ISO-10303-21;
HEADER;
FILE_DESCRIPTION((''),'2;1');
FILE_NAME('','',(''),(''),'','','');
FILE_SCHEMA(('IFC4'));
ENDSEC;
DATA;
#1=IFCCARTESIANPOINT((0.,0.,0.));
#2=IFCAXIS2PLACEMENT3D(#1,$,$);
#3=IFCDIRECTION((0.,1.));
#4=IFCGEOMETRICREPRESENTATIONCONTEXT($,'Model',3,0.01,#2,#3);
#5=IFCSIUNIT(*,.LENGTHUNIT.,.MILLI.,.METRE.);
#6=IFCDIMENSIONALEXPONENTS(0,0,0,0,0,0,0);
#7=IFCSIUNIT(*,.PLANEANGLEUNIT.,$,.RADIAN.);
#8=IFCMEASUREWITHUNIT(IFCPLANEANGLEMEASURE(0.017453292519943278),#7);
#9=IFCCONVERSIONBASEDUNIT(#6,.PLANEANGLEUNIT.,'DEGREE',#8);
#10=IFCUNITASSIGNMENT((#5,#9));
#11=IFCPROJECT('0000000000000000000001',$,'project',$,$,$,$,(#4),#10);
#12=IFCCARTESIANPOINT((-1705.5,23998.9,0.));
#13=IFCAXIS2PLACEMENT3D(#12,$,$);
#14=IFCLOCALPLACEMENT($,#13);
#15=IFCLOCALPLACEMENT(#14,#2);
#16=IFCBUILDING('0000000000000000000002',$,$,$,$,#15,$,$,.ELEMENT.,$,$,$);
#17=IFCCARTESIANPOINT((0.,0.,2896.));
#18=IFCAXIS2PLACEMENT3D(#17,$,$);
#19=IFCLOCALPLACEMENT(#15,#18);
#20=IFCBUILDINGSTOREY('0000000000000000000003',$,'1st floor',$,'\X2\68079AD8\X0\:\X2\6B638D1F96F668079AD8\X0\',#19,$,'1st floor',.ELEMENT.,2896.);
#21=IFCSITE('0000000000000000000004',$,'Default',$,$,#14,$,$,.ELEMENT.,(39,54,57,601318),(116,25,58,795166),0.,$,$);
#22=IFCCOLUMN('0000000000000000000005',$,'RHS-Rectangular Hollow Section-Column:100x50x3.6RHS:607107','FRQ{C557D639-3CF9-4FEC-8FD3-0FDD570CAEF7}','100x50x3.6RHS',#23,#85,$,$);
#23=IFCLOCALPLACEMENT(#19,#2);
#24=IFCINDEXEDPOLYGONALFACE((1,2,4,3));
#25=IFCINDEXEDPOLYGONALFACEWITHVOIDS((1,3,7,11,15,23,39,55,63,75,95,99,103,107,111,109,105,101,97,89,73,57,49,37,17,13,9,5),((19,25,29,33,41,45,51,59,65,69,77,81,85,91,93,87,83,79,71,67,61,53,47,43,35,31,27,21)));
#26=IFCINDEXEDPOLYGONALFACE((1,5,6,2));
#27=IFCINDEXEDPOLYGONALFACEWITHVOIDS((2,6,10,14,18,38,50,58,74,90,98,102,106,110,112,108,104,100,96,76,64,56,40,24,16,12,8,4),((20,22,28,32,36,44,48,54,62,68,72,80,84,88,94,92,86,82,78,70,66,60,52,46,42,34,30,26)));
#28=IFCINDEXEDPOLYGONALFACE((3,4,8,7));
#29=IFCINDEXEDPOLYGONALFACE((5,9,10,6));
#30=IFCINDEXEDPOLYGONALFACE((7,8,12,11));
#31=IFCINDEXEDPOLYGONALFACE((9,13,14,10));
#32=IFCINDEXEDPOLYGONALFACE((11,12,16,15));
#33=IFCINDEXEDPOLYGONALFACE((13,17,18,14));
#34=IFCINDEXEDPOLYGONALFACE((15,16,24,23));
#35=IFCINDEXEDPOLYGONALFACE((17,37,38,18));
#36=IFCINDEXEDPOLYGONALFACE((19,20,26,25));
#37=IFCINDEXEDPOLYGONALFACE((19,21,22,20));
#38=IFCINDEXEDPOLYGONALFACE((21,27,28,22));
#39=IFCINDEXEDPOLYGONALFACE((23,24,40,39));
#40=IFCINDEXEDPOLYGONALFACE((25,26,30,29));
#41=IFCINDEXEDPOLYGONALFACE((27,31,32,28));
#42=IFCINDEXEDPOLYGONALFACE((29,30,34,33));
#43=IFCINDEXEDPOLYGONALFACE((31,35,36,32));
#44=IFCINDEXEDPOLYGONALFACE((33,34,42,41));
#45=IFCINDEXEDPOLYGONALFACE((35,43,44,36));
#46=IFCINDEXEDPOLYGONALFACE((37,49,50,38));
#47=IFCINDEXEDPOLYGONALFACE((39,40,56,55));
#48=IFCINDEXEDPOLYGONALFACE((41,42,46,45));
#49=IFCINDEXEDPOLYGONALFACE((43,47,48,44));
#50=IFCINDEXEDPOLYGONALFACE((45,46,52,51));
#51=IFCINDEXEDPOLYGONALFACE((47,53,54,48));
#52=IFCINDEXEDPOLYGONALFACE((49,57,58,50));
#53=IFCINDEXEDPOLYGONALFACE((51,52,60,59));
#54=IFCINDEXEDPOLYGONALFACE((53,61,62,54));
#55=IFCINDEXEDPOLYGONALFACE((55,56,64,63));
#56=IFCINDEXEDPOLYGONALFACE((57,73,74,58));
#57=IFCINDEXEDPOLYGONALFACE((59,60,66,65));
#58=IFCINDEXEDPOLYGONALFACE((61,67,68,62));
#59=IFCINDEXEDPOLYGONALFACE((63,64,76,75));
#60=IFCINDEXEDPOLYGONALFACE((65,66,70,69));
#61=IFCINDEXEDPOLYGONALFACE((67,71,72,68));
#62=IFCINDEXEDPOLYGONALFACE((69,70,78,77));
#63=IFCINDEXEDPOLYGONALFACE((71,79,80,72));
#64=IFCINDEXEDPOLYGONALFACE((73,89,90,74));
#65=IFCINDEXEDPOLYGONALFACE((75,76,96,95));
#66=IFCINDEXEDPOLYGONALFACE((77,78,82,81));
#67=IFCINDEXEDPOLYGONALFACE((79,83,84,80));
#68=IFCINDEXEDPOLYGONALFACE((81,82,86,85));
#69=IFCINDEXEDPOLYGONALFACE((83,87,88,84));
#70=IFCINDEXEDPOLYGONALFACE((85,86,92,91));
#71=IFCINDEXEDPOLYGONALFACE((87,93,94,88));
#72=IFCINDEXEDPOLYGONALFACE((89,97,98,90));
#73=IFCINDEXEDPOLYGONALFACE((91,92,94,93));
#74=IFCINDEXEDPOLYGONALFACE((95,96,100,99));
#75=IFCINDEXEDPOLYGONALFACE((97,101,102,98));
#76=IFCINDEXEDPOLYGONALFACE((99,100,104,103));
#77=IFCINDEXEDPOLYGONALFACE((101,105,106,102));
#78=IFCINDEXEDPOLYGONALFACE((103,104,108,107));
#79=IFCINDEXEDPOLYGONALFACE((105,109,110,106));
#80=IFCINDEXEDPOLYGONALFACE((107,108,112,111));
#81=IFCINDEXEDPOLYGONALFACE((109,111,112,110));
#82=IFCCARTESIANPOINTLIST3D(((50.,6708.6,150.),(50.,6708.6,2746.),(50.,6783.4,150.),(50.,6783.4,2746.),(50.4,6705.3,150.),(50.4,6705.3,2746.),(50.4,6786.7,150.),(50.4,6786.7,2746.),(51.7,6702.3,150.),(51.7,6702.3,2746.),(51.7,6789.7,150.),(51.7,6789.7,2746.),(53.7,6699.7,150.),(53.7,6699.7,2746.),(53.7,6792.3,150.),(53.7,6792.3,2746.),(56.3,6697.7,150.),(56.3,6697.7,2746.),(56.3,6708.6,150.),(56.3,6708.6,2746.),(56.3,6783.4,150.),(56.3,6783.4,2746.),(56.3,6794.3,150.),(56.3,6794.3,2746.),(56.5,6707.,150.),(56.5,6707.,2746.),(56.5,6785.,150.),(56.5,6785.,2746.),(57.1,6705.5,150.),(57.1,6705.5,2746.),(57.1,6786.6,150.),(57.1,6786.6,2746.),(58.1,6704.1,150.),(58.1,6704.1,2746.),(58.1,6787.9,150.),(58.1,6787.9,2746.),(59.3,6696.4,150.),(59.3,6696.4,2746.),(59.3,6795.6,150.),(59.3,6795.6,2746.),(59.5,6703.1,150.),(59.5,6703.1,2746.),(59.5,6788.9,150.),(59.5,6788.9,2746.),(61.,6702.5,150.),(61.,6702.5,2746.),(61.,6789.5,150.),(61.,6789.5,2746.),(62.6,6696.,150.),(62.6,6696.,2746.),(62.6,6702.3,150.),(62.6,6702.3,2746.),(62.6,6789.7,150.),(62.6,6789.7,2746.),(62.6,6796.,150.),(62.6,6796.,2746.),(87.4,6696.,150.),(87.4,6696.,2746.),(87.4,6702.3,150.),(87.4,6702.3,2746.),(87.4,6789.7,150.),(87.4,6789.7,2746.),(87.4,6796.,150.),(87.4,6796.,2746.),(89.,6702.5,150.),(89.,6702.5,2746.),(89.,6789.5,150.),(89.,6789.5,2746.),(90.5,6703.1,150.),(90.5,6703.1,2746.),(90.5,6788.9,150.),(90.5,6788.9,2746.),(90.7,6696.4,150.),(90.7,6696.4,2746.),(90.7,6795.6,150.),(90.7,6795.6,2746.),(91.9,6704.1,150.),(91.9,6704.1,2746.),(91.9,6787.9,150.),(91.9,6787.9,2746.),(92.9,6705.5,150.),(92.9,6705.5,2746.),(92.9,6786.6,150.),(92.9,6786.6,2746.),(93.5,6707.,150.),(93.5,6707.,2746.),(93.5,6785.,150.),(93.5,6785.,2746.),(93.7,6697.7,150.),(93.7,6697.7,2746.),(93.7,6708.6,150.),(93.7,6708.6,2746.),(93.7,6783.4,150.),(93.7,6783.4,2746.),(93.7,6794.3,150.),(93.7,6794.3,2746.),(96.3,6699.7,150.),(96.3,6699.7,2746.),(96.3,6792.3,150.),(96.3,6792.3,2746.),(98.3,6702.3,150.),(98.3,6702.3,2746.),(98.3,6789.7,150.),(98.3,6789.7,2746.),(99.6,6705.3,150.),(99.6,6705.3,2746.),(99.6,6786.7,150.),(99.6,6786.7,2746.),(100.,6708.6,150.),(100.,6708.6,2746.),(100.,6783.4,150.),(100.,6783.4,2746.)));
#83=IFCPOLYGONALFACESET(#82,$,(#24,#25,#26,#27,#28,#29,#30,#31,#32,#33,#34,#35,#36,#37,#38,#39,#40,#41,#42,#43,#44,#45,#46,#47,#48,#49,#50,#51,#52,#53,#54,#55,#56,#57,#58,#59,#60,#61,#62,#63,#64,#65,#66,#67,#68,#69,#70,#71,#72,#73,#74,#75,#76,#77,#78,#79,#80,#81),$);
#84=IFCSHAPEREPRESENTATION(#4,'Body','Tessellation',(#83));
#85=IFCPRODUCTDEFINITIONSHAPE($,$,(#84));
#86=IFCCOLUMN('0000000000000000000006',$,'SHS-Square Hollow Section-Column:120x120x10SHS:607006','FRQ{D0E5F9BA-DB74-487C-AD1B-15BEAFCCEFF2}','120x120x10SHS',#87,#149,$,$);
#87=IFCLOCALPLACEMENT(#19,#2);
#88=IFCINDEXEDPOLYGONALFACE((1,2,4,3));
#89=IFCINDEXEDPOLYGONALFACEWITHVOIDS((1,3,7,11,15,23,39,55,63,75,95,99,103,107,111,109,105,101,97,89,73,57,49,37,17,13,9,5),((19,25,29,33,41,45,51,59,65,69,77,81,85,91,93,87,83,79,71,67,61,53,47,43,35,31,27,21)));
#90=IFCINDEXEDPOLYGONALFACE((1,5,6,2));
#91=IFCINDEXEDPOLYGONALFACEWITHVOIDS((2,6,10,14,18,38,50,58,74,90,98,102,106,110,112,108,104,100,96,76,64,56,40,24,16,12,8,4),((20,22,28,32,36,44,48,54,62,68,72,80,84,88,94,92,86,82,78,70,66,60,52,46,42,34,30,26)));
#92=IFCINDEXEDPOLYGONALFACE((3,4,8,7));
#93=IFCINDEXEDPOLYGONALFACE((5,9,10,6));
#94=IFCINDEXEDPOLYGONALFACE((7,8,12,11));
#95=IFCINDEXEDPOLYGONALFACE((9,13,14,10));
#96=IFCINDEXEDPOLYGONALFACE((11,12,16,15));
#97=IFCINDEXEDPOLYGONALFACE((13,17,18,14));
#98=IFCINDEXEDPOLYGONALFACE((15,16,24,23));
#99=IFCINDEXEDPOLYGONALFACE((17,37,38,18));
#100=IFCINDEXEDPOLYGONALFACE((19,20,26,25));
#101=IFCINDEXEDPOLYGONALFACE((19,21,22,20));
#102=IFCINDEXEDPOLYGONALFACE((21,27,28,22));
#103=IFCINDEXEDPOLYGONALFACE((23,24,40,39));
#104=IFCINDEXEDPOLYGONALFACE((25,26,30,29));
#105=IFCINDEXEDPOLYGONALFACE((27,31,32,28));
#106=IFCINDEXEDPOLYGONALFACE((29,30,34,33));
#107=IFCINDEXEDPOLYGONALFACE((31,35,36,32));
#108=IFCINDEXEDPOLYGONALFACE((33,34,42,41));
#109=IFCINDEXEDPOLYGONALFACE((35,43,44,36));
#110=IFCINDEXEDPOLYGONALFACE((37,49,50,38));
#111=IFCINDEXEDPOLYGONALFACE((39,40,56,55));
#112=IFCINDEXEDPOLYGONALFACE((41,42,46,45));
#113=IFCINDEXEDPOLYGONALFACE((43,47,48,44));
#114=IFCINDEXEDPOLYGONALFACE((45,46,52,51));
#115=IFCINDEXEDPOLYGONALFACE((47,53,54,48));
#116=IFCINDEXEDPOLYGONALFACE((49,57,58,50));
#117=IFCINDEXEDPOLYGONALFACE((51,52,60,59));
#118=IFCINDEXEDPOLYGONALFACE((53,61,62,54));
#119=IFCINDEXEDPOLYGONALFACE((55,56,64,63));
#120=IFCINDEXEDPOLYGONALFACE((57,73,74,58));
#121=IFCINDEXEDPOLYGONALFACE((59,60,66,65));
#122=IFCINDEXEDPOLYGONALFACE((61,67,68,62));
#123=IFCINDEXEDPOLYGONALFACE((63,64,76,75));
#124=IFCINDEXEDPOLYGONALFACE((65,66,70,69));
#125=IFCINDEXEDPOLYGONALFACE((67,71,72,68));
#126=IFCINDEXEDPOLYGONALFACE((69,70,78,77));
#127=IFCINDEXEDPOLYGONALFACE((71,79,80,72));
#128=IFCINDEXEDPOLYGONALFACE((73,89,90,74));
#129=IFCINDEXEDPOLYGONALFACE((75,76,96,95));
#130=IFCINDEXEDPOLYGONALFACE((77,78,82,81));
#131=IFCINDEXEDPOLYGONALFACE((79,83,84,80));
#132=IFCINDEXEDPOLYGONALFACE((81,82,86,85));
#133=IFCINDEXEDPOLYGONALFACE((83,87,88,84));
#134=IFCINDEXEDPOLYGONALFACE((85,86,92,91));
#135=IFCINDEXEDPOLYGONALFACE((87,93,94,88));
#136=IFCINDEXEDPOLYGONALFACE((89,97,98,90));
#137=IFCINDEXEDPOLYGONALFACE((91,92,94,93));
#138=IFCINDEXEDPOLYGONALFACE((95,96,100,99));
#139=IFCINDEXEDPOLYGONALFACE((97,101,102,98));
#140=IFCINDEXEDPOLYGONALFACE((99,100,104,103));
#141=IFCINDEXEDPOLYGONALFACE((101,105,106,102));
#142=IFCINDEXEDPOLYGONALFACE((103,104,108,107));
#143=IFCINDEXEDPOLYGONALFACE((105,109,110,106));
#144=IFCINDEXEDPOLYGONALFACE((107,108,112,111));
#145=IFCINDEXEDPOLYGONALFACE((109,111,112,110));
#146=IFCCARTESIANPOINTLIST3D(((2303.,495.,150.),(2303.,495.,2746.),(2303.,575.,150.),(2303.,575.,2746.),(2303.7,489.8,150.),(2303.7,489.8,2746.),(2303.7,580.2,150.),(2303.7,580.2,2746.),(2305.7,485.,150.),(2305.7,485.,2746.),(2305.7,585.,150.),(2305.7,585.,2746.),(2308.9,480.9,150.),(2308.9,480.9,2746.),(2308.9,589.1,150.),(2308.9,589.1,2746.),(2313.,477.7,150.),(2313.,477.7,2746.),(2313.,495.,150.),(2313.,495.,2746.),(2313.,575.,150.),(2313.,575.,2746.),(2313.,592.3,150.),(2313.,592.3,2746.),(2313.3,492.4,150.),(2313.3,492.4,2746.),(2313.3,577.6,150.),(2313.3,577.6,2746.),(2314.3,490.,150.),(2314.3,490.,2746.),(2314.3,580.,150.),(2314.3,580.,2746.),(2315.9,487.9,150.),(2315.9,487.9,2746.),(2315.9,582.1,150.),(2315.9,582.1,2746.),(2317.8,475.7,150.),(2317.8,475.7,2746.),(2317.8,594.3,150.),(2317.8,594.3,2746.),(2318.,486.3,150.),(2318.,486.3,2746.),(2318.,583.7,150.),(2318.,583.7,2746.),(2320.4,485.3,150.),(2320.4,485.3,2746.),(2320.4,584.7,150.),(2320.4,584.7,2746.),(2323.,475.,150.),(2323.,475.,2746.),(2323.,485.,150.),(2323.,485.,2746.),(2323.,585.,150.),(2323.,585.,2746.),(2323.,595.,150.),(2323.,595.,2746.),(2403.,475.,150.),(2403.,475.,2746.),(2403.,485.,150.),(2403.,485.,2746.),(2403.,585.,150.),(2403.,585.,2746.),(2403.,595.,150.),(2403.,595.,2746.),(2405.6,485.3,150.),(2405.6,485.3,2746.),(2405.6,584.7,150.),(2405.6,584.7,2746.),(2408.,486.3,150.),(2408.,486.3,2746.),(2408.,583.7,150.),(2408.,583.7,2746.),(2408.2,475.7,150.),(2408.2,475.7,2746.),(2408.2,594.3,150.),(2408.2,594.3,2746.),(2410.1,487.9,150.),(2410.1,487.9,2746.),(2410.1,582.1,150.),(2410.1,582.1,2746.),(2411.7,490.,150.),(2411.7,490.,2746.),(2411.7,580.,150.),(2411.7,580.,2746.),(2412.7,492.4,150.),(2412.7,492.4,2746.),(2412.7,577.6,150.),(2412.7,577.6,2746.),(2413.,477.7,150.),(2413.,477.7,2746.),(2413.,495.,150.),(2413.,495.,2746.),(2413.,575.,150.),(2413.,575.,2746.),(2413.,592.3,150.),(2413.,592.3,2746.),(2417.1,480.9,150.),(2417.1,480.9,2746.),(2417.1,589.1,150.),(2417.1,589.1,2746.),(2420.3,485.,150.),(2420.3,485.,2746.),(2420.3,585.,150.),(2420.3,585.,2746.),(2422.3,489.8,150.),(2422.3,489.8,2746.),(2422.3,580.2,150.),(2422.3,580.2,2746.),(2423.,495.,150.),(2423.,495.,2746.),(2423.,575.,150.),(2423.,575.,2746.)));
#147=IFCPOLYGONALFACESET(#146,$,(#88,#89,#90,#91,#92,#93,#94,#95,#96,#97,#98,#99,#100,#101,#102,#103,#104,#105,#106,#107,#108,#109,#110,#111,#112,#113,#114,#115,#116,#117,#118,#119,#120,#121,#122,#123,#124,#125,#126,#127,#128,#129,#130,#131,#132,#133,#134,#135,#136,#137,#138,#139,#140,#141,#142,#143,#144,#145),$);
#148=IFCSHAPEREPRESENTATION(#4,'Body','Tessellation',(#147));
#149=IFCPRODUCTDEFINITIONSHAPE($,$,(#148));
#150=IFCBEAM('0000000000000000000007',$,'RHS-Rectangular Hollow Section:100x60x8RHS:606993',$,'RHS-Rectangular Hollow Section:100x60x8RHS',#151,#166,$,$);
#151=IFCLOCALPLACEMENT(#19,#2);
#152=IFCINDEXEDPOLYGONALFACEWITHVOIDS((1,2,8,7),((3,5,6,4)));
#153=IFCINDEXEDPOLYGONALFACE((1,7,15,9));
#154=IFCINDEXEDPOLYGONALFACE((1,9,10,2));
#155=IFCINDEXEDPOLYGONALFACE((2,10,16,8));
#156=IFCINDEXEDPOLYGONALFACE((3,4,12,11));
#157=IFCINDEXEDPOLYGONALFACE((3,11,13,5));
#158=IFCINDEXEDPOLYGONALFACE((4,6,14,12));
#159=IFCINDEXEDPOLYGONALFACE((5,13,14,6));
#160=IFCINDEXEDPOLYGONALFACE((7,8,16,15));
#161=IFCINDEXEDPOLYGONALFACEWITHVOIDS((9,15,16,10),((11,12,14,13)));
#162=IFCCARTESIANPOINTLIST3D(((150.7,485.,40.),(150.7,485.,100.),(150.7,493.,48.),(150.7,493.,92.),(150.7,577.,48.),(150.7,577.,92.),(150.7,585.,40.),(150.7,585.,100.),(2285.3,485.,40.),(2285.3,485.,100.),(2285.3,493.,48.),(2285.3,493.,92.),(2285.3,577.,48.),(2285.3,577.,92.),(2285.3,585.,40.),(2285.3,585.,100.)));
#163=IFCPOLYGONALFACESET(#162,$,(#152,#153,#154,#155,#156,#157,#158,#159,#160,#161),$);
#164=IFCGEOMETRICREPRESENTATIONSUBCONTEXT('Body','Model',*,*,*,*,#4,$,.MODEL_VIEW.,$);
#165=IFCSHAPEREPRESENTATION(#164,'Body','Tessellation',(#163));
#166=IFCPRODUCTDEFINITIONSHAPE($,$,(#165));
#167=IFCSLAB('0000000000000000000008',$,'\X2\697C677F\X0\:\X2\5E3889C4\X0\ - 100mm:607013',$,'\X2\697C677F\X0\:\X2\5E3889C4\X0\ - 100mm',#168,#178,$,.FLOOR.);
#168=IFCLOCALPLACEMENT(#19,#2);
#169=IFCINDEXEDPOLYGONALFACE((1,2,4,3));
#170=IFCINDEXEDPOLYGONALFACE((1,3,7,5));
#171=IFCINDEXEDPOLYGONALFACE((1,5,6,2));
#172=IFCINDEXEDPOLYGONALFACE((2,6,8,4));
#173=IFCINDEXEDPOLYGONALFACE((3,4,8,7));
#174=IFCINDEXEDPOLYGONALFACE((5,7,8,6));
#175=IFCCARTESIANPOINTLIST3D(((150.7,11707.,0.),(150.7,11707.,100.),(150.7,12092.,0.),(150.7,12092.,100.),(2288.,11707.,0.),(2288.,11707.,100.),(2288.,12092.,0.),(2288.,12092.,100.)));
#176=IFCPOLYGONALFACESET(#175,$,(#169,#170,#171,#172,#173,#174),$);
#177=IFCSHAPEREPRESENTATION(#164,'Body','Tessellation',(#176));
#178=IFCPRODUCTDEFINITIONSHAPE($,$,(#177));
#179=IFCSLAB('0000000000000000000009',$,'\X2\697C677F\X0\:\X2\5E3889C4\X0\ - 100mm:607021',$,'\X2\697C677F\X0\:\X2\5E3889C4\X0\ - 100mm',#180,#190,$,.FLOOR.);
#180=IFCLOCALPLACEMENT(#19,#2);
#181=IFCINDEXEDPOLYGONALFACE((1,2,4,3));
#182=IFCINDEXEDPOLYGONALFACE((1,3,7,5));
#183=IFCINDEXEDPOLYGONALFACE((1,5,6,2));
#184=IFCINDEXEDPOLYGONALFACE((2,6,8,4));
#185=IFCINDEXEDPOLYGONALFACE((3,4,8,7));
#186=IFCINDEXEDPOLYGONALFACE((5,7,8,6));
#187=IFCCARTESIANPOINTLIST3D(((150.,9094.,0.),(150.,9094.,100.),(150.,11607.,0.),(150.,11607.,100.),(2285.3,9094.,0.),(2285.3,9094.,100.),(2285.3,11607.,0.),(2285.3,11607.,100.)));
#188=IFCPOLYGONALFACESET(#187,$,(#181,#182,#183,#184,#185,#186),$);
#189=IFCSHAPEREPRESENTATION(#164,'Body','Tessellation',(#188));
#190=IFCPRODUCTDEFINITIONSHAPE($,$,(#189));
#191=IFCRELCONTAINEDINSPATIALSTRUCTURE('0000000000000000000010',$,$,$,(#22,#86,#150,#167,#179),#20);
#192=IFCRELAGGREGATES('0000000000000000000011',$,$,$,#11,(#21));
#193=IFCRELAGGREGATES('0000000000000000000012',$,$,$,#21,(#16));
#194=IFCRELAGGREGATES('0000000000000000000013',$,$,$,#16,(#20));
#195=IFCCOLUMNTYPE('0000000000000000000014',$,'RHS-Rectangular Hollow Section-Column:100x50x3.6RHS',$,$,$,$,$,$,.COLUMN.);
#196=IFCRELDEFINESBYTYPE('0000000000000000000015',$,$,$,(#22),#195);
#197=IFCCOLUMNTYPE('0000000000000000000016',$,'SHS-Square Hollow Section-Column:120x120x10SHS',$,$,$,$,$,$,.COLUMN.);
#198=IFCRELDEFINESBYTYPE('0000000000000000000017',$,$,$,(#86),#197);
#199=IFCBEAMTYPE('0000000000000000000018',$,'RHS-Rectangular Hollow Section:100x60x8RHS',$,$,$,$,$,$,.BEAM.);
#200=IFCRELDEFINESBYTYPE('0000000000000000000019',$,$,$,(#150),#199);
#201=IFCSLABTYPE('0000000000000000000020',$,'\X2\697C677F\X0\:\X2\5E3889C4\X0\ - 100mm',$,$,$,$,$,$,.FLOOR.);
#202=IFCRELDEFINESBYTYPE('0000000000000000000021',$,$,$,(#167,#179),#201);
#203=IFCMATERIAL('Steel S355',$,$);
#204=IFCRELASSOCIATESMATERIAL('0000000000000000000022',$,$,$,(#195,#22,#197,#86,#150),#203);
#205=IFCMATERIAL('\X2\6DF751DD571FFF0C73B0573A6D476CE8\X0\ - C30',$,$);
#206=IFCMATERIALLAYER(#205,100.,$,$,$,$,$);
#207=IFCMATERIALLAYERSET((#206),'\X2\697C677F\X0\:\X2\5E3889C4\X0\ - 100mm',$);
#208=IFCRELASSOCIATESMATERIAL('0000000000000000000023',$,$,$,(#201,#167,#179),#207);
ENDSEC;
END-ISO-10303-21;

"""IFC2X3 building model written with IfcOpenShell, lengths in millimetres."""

from ifc_helpers import new_model, entity, si_unit, converted_unit, direction, frame, frame_2d, origin, origin_2d, origin_2d_with_axis, place, context, subcontext, project, spatial, rectangle, hollow_rectangle, extrude, boolean, clip, halfspace, material, layer, layer_set, layer_usage, type_object, element, save


model = new_model("IFC2X3")

# Units and contexts
model_context = context("Model", 3, precision=0.01, world=origin(), true_north=direction((0.0, 1.0)))
body_context = subcontext(model_context, "Body", "Model", "MODEL_VIEW")
ifc_project = project(units=[si_unit("LENGTHUNIT", "METRE", prefix="MILLI"), converted_unit("PLANEANGLEUNIT", "DEGREE", entity("IfcPlaneAngleMeasure", 0.017453292519943278), si_unit("PLANEANGLEUNIT", "RADIAN"), dimensions=[0, 0, 0, 0, 0, 0, 0])], contexts=[model_context])

# Site, building, storey
site_placement = place(None, frame((-1705.5, 23998.9, 0.0)))
site = spatial("IfcSite", under=ifc_project, at=site_placement, Name="Default", CompositionType="ELEMENT", RefLatitude=(39, 54, 57, 601318), RefLongitude=(116, 25, 58, 795166), RefElevation=0.0)
building_placement = place(site_placement, origin())
building = spatial("IfcBuilding", under=site, at=building_placement, CompositionType="ELEMENT")
storey_placement = place(building_placement, frame((0.0, 0.0, 2896.0)))
storey = spatial("IfcBuildingStorey", under=building, at=storey_placement, Name="1st floor", ObjectType="标高:正负零标高", LongName="1st floor", CompositionType="ELEMENT", Elevation=2896.0)

# Shared definitions
ifc_material_1 = material(Name="Steel S355")

# Columns
column_type_1 = type_object("IfcColumnType", Name="RHS-Rectangular Hollow Section-Column:100x50x3.6RHS", PredefinedType="COLUMN", material=ifc_material_1)
column_1_placement = place(storey_placement, frame((75.0, 6746.0, 2746.0), z_axis=(0.0, 0.0, 1.0), x_axis=(-1.0, 0.0, 0.0)))
element("IfcColumn", 1, at=column_1_placement, inside=storey, type_object=column_type_1, material=ifc_material_1, Name="RHS-Rectangular Hollow Section-Column:100x50x3.6RHS:607107", Description="FRQ{C557D639-3CF9-4FEC-8FD3-0FDD570CAEF7}", ObjectType="100x50x3.6RHS", context=model_context, shape_type="Clipping", body=[
    clip(extrude(hollow_rectangle(XDim=50.0, YDim=100.0, WallThickness=6.3, InnerFilletRadius=6.3, OuterFilletRadius=12.6, at=origin_2d()), origin(), (0.0, 0.0, -1.0), 2651.9), halfspace(frame((75.0, 6746.0, -2596.0), z_axis=(0.0, 0.0, 1.0), x_axis=(-1.0, 0.0, 0.0)), True)),
])
column_type_2 = type_object("IfcColumnType", Name="SHS-Square Hollow Section-Column:120x120x10SHS", PredefinedType="COLUMN", material=ifc_material_1)
column_2_placement = place(storey_placement, frame((2363.0, 535.0, 2746.0), z_axis=(0.0, 0.0, 1.0), x_axis=(0.0, -1.0, 0.0)))
element("IfcColumn", 2, at=column_2_placement, inside=storey, type_object=column_type_2, material=ifc_material_1, Name="SHS-Square Hollow Section-Column:120x120x10SHS:607006", Description="FRQ{D0E5F9BA-DB74-487C-AD1B-15BEAFCCEFF2}", ObjectType="120x120x10SHS", context=model_context, shape_type="Clipping", body=[
    clip(extrude(hollow_rectangle(XDim=120.0, YDim=120.0, WallThickness=10.0, InnerFilletRadius=10.0, OuterFilletRadius=20.0, at=origin_2d()), origin(), (0.0, 0.0, -1.0), 2680.9), halfspace(frame((535.0, -2363.0, -2596.0), z_axis=(0.0, 0.0, 1.0), x_axis=(0.0, 1.0, 0.0)), True)),
])

# Beam
beam_type_1 = type_object("IfcBeamType", Name="RHS-Rectangular Hollow Section:100x60x8RHS", PredefinedType="BEAM")
beam_1_placement = place(storey_placement, frame((150.7, 585.0, 70.0)))
element("IfcBeam", 3, at=beam_1_placement, inside=storey, type_object=beam_type_1, material=ifc_material_1, Name="RHS-Rectangular Hollow Section:100x60x8RHS:606993", ObjectType="RHS-Rectangular Hollow Section:100x60x8RHS", context=body_context, shape_type="SweptSolid", body=[
    boolean("DIFFERENCE", extrude(rectangle(XDim=60.0, YDim=100.0, at=frame_2d((0.0, 0.0), x_axis=(1.0, 0.0))), frame((0.0, -50.0, 0.0), z_axis=(1.0, 0.0, 0.0), x_axis=(0.0, 0.0, -1.0)), (0.0, 0.0, 1.0), 2134.6), extrude(rectangle(XDim=44.0, YDim=84.0, at=frame_2d((0.0, 0.0), x_axis=(0.0, 1.0))), frame((2134.6, -50.0, 0.0), z_axis=(-1.0, 0.0, 0.0), x_axis=(0.0, 1.0, 0.0)), (0.0, 0.0, 1.0), 2134.6)),
])

# Slabs
ifc_material_2 = material(Name="混凝土，现场浇注 - C30")
ifc_layer_1 = layer(ifc_material_2, 100.0)
ifc_layer_set_1 = layer_set([ifc_layer_1], Name="楼板:常规 - 100mm")
ifc_layer_usage_1 = layer_usage(ifc_layer_set_1, "AXIS3", "POSITIVE", 0.0)
slab_type = type_object("IfcSlabType", Name="楼板:常规 - 100mm", PredefinedType="FLOOR", material=ifc_layer_set_1)
slab_1_placement = place(storey_placement, origin())
element("IfcSlab", 4, at=slab_1_placement, inside=storey, type_object=slab_type, material=ifc_layer_usage_1, Name="楼板:常规 - 100mm:607013", ObjectType="楼板:常规 - 100mm", PredefinedType="FLOOR", context=body_context, shape_type="SweptSolid", body=[
    extrude(rectangle(XDim=385.0, YDim=2137.3, at=origin_2d_with_axis()), frame((1219.3, 11899.5, 100.0), z_axis=(0.0, 0.0, -1.0), x_axis=(0.0, 1.0, 0.0)), (0.0, 0.0, 1.0), 100.0),
])
ifc_layer_usage_2 = layer_usage(ifc_layer_set_1, "AXIS3", "POSITIVE", 0.0)
slab_2_placement = place(storey_placement, origin())
element("IfcSlab", 5, at=slab_2_placement, inside=storey, type_object=slab_type, material=ifc_layer_usage_2, Name="楼板:常规 - 100mm:607021", ObjectType="楼板:常规 - 100mm", PredefinedType="FLOOR", context=body_context, shape_type="SweptSolid", body=[
    extrude(rectangle(XDim=2513.0, YDim=2135.3, at=frame_2d((0.0, 0.0), x_axis=(1.0, 0.0))), frame((1217.7, 10350.5, 100.0), z_axis=(0.0, 0.0, -1.0), x_axis=(0.0, 1.0, 0.0)), (0.0, 0.0, 1.0), 100.0),
])

save(model, "model.ifc")
